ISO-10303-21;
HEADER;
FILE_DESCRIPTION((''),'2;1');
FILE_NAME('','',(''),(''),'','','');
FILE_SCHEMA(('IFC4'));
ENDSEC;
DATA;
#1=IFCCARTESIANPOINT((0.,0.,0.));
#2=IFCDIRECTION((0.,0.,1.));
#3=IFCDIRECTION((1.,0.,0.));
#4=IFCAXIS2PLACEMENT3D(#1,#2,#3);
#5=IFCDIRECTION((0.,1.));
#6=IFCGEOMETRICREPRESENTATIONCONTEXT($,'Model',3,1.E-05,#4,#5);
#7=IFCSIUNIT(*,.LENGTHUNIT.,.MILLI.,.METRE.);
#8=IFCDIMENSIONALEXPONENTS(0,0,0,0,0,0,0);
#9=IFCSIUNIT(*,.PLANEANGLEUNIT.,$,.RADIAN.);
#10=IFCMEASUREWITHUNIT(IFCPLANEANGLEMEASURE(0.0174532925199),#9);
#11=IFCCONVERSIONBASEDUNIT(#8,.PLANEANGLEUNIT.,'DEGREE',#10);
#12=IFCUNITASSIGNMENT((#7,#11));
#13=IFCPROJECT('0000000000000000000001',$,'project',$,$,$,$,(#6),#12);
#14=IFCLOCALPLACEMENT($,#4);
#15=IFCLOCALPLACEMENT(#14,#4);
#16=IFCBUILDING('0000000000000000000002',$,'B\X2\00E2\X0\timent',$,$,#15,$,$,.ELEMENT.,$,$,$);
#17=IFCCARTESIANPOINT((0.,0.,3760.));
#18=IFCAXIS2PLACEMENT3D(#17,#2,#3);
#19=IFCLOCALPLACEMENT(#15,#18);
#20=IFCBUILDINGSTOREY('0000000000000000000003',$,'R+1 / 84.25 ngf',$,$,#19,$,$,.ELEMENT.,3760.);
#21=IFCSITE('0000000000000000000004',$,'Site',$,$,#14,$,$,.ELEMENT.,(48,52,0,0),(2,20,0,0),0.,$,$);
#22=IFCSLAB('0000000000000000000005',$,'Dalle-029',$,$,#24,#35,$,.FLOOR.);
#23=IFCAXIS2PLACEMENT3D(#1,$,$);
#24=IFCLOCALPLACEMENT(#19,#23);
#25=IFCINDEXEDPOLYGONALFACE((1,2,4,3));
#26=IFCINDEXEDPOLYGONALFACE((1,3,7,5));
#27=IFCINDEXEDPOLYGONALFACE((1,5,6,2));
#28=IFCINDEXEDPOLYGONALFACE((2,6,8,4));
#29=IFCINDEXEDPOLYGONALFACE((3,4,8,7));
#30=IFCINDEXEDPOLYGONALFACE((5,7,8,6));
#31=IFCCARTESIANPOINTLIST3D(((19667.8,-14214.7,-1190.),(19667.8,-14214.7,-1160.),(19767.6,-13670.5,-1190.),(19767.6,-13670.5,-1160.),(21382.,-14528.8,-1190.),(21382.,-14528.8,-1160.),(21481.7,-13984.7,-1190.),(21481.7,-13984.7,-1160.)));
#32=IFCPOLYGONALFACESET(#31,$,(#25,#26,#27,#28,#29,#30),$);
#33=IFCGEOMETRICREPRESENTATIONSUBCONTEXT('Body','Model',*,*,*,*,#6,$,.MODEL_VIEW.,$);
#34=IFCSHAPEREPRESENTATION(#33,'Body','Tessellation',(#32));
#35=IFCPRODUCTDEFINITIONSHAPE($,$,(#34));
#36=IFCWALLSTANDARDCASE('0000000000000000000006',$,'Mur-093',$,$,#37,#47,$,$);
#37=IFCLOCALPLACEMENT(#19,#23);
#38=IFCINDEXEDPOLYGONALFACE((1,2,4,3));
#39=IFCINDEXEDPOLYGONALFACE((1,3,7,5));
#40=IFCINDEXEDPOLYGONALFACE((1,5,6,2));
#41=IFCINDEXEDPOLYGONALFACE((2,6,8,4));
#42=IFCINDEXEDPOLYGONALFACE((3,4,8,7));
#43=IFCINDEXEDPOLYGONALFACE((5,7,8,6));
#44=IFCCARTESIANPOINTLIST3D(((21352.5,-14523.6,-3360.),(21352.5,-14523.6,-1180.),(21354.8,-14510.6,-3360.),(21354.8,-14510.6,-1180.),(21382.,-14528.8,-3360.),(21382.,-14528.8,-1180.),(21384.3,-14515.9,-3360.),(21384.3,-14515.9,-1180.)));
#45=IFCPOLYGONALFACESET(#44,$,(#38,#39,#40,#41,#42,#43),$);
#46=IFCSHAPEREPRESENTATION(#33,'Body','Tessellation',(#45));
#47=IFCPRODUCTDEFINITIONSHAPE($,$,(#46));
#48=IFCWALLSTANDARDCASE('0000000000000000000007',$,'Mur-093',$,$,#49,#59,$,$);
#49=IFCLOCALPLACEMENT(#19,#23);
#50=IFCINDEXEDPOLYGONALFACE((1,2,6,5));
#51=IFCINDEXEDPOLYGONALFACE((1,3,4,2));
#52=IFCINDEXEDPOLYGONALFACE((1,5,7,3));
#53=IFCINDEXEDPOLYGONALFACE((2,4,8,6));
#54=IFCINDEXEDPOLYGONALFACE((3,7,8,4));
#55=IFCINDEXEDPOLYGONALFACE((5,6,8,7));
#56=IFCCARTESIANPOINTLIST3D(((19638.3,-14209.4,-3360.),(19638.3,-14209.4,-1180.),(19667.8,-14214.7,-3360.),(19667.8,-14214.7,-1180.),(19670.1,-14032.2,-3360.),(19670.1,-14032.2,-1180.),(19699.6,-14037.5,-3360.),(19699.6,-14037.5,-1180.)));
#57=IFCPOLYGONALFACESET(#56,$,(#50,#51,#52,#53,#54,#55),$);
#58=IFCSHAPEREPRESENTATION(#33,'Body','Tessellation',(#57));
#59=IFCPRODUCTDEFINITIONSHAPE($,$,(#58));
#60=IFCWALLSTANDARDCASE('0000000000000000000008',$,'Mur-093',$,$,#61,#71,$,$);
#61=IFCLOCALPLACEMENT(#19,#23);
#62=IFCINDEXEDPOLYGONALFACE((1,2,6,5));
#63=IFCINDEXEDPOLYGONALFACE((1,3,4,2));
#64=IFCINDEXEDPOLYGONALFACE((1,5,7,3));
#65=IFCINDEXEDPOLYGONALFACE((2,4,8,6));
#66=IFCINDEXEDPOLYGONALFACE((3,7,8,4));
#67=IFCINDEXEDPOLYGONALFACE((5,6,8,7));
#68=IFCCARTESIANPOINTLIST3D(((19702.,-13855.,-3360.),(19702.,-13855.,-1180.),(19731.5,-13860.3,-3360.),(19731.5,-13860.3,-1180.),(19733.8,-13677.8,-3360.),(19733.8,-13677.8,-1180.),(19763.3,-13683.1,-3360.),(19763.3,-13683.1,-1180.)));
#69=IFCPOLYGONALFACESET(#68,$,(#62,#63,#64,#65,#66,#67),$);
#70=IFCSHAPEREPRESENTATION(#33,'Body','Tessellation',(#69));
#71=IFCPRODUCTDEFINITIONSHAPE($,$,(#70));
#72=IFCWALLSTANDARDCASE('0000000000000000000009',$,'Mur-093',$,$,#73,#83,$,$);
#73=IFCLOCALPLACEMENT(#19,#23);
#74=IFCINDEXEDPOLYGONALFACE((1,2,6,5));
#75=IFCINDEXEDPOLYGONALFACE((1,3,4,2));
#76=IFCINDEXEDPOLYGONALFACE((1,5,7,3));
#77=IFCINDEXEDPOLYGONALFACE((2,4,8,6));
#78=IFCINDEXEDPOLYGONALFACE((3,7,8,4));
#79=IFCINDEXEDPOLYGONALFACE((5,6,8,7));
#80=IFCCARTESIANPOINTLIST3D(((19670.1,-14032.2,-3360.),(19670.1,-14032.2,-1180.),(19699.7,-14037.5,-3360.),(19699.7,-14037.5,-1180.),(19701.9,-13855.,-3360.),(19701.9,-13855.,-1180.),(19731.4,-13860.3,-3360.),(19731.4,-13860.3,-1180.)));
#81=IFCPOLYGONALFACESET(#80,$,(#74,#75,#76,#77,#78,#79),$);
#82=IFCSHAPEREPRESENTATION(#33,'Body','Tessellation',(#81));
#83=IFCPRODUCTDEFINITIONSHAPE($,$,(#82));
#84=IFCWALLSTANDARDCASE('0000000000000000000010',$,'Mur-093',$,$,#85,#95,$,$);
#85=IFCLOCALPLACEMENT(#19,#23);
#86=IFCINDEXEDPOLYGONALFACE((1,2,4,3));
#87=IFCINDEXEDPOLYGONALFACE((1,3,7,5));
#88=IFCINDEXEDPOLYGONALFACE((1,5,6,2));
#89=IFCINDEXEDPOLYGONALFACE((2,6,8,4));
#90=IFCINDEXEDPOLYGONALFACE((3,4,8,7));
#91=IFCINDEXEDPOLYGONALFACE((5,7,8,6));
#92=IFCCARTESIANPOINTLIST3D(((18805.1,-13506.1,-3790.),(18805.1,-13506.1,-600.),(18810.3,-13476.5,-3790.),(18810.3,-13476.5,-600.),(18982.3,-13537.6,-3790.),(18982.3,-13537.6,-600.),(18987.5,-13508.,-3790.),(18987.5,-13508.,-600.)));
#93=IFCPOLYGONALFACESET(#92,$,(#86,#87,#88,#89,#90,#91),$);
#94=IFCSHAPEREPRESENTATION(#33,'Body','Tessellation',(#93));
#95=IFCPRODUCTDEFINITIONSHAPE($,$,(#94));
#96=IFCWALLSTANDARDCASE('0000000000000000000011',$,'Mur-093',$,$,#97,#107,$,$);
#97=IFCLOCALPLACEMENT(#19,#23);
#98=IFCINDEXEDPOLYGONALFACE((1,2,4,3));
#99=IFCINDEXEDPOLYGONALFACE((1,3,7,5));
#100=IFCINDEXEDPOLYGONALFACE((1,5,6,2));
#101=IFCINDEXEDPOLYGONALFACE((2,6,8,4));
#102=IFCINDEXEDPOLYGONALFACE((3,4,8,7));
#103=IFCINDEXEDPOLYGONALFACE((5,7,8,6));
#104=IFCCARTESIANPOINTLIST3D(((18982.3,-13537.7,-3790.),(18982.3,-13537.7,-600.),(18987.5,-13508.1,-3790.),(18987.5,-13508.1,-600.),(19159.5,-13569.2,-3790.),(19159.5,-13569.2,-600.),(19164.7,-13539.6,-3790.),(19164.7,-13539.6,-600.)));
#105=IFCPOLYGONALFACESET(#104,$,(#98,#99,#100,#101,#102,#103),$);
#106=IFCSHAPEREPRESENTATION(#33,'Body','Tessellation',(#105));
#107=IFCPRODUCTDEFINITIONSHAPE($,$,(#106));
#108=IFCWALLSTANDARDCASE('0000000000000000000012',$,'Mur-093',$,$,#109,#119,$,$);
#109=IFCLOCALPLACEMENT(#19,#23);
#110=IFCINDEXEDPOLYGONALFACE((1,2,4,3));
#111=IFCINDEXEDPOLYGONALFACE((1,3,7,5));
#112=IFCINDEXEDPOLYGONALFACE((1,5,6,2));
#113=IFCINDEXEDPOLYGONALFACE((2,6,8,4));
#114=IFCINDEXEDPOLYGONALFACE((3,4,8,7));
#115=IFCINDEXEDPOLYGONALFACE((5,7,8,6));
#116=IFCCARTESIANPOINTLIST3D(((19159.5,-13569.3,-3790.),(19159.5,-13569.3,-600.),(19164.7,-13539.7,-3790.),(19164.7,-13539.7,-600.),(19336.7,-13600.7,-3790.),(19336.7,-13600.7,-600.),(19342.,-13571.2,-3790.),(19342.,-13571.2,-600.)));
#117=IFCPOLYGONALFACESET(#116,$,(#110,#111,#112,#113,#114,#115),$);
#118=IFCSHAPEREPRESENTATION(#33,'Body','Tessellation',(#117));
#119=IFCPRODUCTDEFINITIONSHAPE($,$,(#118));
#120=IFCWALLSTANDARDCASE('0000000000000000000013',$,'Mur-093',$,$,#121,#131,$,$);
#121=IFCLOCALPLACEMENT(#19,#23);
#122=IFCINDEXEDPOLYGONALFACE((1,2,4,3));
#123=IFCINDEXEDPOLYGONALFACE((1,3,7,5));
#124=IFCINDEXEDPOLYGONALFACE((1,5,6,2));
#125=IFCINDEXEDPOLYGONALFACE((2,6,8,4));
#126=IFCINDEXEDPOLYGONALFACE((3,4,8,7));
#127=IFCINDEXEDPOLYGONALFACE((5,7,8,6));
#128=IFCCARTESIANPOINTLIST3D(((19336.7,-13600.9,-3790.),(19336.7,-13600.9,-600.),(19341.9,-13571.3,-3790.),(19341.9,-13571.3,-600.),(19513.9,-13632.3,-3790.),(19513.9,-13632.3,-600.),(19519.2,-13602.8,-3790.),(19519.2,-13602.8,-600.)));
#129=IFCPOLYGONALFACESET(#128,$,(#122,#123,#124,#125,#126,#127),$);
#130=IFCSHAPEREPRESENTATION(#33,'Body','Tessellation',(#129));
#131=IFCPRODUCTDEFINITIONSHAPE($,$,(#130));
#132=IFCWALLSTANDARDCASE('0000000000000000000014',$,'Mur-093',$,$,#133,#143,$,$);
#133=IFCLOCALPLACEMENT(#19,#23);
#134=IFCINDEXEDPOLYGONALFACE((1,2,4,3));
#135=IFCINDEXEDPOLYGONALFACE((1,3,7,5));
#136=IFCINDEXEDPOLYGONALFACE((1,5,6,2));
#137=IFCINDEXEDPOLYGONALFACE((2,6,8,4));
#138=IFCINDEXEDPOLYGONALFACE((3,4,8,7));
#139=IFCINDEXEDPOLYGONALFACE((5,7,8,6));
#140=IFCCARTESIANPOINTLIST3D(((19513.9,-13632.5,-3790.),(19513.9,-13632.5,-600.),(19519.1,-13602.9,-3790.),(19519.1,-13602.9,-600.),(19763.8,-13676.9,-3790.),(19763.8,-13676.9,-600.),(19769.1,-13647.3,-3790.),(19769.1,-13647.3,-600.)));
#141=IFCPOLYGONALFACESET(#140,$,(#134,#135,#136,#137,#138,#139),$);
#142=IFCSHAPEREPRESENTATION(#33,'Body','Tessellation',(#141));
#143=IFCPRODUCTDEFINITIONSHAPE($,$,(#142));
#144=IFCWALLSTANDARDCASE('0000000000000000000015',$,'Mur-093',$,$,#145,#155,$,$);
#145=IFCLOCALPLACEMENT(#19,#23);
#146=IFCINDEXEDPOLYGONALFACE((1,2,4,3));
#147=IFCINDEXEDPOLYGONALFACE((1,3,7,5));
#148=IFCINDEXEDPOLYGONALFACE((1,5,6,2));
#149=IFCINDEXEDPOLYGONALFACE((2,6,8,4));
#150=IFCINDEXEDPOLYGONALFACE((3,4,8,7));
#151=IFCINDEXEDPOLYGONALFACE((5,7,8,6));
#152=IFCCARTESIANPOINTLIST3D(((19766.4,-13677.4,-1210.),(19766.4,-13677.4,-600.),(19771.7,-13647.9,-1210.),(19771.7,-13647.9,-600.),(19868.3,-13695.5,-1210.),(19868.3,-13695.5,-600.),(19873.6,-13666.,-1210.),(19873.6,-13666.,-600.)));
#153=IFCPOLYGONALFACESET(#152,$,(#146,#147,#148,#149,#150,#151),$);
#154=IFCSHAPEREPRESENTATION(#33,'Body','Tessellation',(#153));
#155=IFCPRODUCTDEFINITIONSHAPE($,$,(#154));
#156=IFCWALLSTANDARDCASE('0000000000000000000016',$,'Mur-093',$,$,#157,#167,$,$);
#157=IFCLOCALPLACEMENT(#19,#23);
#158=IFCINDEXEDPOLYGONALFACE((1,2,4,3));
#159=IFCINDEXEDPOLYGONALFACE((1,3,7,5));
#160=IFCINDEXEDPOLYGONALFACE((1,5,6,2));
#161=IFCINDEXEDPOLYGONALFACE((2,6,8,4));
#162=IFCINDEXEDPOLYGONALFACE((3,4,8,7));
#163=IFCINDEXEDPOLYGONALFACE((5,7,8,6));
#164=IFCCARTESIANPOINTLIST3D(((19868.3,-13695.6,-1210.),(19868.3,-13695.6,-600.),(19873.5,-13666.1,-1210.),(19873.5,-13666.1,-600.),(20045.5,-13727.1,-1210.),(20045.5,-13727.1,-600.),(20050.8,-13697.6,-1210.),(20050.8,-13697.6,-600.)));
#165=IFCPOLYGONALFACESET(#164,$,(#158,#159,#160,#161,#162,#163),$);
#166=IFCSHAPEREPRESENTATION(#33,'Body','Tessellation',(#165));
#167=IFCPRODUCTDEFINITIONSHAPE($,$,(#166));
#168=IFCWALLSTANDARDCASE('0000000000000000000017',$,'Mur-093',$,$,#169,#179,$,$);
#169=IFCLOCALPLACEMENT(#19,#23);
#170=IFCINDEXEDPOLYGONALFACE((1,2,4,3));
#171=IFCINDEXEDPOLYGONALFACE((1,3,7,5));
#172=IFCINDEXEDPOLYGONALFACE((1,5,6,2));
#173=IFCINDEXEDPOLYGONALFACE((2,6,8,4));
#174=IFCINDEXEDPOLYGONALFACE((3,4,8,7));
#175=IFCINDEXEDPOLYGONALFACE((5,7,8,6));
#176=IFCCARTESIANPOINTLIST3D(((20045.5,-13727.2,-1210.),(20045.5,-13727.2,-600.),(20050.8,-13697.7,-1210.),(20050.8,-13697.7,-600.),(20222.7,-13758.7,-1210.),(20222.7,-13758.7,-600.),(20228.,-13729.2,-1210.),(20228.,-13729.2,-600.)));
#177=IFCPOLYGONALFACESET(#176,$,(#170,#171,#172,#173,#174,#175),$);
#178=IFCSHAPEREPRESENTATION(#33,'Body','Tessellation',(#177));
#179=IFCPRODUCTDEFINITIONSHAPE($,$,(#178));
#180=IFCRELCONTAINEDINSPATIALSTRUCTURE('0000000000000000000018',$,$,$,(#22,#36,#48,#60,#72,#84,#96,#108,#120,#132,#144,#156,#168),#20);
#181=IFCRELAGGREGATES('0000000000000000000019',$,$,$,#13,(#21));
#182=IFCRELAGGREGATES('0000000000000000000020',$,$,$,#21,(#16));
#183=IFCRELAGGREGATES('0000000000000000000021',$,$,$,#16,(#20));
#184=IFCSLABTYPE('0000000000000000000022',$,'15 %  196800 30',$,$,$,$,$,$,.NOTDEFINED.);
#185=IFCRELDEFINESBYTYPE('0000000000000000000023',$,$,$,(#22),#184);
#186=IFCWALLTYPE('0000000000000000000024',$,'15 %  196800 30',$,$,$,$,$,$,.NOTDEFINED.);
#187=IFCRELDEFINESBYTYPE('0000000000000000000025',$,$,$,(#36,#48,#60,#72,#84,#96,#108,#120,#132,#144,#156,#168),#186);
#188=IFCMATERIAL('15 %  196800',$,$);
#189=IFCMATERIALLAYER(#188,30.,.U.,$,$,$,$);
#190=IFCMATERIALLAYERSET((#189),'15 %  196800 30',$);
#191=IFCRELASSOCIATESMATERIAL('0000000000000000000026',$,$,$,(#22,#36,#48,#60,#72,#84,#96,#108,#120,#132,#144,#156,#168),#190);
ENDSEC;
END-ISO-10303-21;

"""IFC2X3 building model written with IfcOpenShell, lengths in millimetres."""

from ifc_helpers import new_model, entity, si_unit, converted_unit, direction, frame, origin_with_axes, place, context, subcontext, project, spatial, polyline, outline, extrude, material, layer, layer_set, layer_usage, type_object, element, save


model = new_model("IFC2X3")

# Units and contexts
model_context = context("Model", 3, precision=1e-05, world=origin_with_axes(), true_north=direction((0.0, 1.0)))
body_context = subcontext(model_context, "Body", "Model", "MODEL_VIEW")
ifc_project = project(units=[si_unit("LENGTHUNIT", "METRE", prefix="MILLI"), converted_unit("PLANEANGLEUNIT", "DEGREE", entity("IfcPlaneAngleMeasure", 0.0174532925199), si_unit("PLANEANGLEUNIT", "RADIAN"), dimensions=[0, 0, 0, 0, 0, 0, 0])], contexts=[model_context])

# Site, building, storey
site_placement = place(None, origin_with_axes())
site = spatial("IfcSite", under=ifc_project, at=site_placement, Name="Site", CompositionType="ELEMENT", RefLatitude=(48, 52, 0, 0), RefLongitude=(2, 20, 0, 0), RefElevation=0.0)
building_placement = place(site_placement, origin_with_axes())
building = spatial("IfcBuilding", under=site, at=building_placement, Name="Bâtiment", CompositionType="ELEMENT")
storey_placement = place(building_placement, frame((0.0, 0.0, 3760.0), z_axis=(0.0, 0.0, 1.0), x_axis=(1.0, 0.0, 0.0)))
storey = spatial("IfcBuildingStorey", under=building, at=storey_placement, Name="R+1 / 84.25 ngf", CompositionType="ELEMENT", Elevation=3760.0)

# Slab
ifc_material = material(Name="15 %  196800")
ifc_layer = layer(ifc_material, 30.0, ventilated="UNKNOWN")
ifc_layer_set = layer_set([ifc_layer], Name="15 %  196800 30")
ifc_layer_usage_1 = layer_usage(ifc_layer_set, "AXIS3", "NEGATIVE", 30.0)
slab_type = type_object("IfcSlabType", Name="15 %  196800 30", PredefinedType="NOTDEFINED")
slab_placement = place(storey_placement, frame((21382.0, -14528.8, -1160.0), z_axis=(0.0, 0.0, 1.0), x_axis=(1.0, 0.0, 0.0)))
element("IfcSlab", 1, at=slab_placement, inside=storey, type_object=slab_type, material=ifc_layer_usage_1, Name="Dalle-029", PredefinedType="FLOOR", context=body_context, shape_type="SweptSolid", body=[
    extrude(outline(polyline([(0.0, 0.0), (99.7, 544.1), (-1614.5, 858.3), (-1714.2, 314.2), (0.0, 0.0)])), frame((0.0, 0.0, -30.0), z_axis=(0.0, 0.0, 1.0), x_axis=(1.0, 0.0, 0.0)), (0.0, 0.0, 1.0), 30.0),
])

# Walls
ifc_layer_usage_2 = layer_usage(ifc_layer_set, "AXIS2", "NEGATIVE", 30.0)
wall_type = type_object("IfcWallType", Name="15 %  196800 30", PredefinedType="NOTDEFINED")
wall_1_placement = place(storey_placement, frame((21354.8, -14510.6, -3360.0), z_axis=(0.0, 0.0, 1.0), x_axis=(-0.176462, -0.984308, 0.0)))
element("IfcWallStandardCase", 2, at=wall_1_placement, inside=storey, type_object=wall_type, material=ifc_layer_usage_2, Name="Mur-093", context=body_context, shape_type="SweptSolid", body=[
    extrude(outline(polyline([(0.0, 0.0), (13.1, 0.0), (13.1, 30.0), (0.0, 30.0), (0.0, 0.0)])), origin_with_axes(), (0.0, 0.0, 1.0), 2180.0),
])
ifc_layer_usage_3 = layer_usage(ifc_layer_set, "AXIS2", "POSITIVE", -30.0)
wall_2_placement = place(storey_placement, frame((19699.6, -14037.5, -3360.0), z_axis=(0.0, 0.0, 1.0), x_axis=(-0.176462, -0.984308, 0.0)))
element("IfcWallStandardCase", 3, at=wall_2_placement, inside=storey, type_object=wall_type, material=ifc_layer_usage_3, Name="Mur-093", context=body_context, shape_type="SweptSolid", body=[
    extrude(outline(polyline([(0.0, -30.0), (180.0, -30.0), (180.0, 0.0), (0.0, 0.0), (0.0, -30.0)])), origin_with_axes(), (0.0, 0.0, 1.0), 2180.0),
])
ifc_layer_usage_4 = layer_usage(ifc_layer_set, "AXIS2", "POSITIVE", -30.0)
wall_3_placement = place(storey_placement, frame((19763.3, -13683.1, -3360.0), z_axis=(0.0, 0.0, 1.0), x_axis=(-0.176462, -0.984308, 0.0)))
element("IfcWallStandardCase", 4, at=wall_3_placement, inside=storey, type_object=wall_type, material=ifc_layer_usage_4, Name="Mur-093", context=body_context, shape_type="SweptSolid", body=[
    extrude(outline(polyline([(0.0, -30.0), (180.0, -30.0), (180.0, 0.0), (0.0, 0.0), (0.0, -30.0)])), origin_with_axes(), (0.0, 0.0, 1.0), 2180.0),
])
ifc_layer_usage_5 = layer_usage(ifc_layer_set, "AXIS2", "POSITIVE", -30.0)
wall_4_placement = place(storey_placement, frame((19731.4, -13860.3, -3360.0), z_axis=(0.0, 0.0, 1.0), x_axis=(-0.176462, -0.984308, 0.0)))
element("IfcWallStandardCase", 5, at=wall_4_placement, inside=storey, type_object=wall_type, material=ifc_layer_usage_5, Name="Mur-093", context=body_context, shape_type="SweptSolid", body=[
    extrude(outline(polyline([(0.0, -30.0), (180.0, -30.0), (180.0, 0.0), (0.0, 0.0), (0.0, -30.0)])), origin_with_axes(), (0.0, 0.0, 1.0), 2180.0),
])
ifc_layer_usage_6 = layer_usage(ifc_layer_set, "AXIS2", "NEGATIVE", 30.0)
wall_5_placement = place(storey_placement, frame((18987.5, -13508.0, -3790.0), z_axis=(0.0, 0.0, 1.0), x_axis=(-0.984592, 0.174869, 0.0)))
element("IfcWallStandardCase", 6, at=wall_5_placement, inside=storey, type_object=wall_type, material=ifc_layer_usage_6, Name="Mur-093", context=body_context, shape_type="SweptSolid", body=[
    extrude(outline(polyline([(0.0, 0.0), (180.0, 0.0), (180.0, 30.0), (0.0, 30.0), (0.0, 0.0)])), origin_with_axes(), (0.0, 0.0, 1.0), 3190.0),
])
ifc_layer_usage_7 = layer_usage(ifc_layer_set, "AXIS2", "NEGATIVE", 30.0)
wall_6_placement = place(storey_placement, frame((19164.7, -13539.6, -3790.0), z_axis=(0.0, 0.0, 1.0), x_axis=(-0.984592, 0.174869, 0.0)))
element("IfcWallStandardCase", 7, at=wall_6_placement, inside=storey, type_object=wall_type, material=ifc_layer_usage_7, Name="Mur-093", context=body_context, shape_type="SweptSolid", body=[
    extrude(outline(polyline([(0.0, 0.0), (180.0, 0.0), (180.0, 30.0), (0.0, 30.0), (0.0, 0.0)])), origin_with_axes(), (0.0, 0.0, 1.0), 3190.0),
])
ifc_layer_usage_8 = layer_usage(ifc_layer_set, "AXIS2", "NEGATIVE", 30.0)
wall_7_placement = place(storey_placement, frame((19342.0, -13571.2, -3790.0), z_axis=(0.0, 0.0, 1.0), x_axis=(-0.984592, 0.174869, 0.0)))
element("IfcWallStandardCase", 8, at=wall_7_placement, inside=storey, type_object=wall_type, material=ifc_layer_usage_8, Name="Mur-093", context=body_context, shape_type="SweptSolid", body=[
    extrude(outline(polyline([(0.0, 0.0), (180.0, 0.0), (180.0, 30.0), (0.0, 30.0), (0.0, 0.0)])), origin_with_axes(), (0.0, 0.0, 1.0), 3190.0),
])
ifc_layer_usage_9 = layer_usage(ifc_layer_set, "AXIS2", "NEGATIVE", 30.0)
wall_8_placement = place(storey_placement, frame((19519.2, -13602.8, -3790.0), z_axis=(0.0, 0.0, 1.0), x_axis=(-0.984592, 0.174869, 0.0)))
element("IfcWallStandardCase", 9, at=wall_8_placement, inside=storey, type_object=wall_type, material=ifc_layer_usage_9, Name="Mur-093", context=body_context, shape_type="SweptSolid", body=[
    extrude(outline(polyline([(0.0, 0.0), (180.0, 0.0), (180.0, 30.0), (0.0, 30.0), (0.0, 0.0)])), origin_with_axes(), (0.0, 0.0, 1.0), 3190.0),
])
ifc_layer_usage_10 = layer_usage(ifc_layer_set, "AXIS2", "NEGATIVE", 30.0)
wall_9_placement = place(storey_placement, frame((19769.1, -13647.3, -3790.0), z_axis=(0.0, 0.0, 1.0), x_axis=(-0.984592, 0.174869, 0.0)))
element("IfcWallStandardCase", 10, at=wall_9_placement, inside=storey, type_object=wall_type, material=ifc_layer_usage_10, Name="Mur-093", context=body_context, shape_type="SweptSolid", body=[
    extrude(outline(polyline([(0.0, 0.0), (253.9, 0.0), (253.9, 30.0), (0.0, 30.0), (0.0, 0.0)])), origin_with_axes(), (0.0, 0.0, 1.0), 3190.0),
])
ifc_layer_usage_11 = layer_usage(ifc_layer_set, "AXIS2", "NEGATIVE", 30.0)
wall_10_placement = place(storey_placement, frame((19873.6, -13666.0, -1210.0), z_axis=(0.0, 0.0, 1.0), x_axis=(-0.984592, 0.174869, 0.0)))
element("IfcWallStandardCase", 11, at=wall_10_placement, inside=storey, type_object=wall_type, material=ifc_layer_usage_11, Name="Mur-093", context=body_context, shape_type="SweptSolid", body=[
    extrude(outline(polyline([(0.0, 0.0), (103.5, 0.0), (103.5, 30.0), (0.0, 30.0), (0.0, 0.0)])), origin_with_axes(), (0.0, 0.0, 1.0), 610.0),
])
ifc_layer_usage_12 = layer_usage(ifc_layer_set, "AXIS2", "NEGATIVE", 30.0)
wall_11_placement = place(storey_placement, frame((20050.8, -13697.6, -1210.0), z_axis=(0.0, 0.0, 1.0), x_axis=(-0.984592, 0.174869, 0.0)))
element("IfcWallStandardCase", 12, at=wall_11_placement, inside=storey, type_object=wall_type, material=ifc_layer_usage_12, Name="Mur-093", context=body_context, shape_type="SweptSolid", body=[
    extrude(outline(polyline([(0.0, 0.0), (180.0, 0.0), (180.0, 30.0), (0.0, 30.0), (0.0, 0.0)])), origin_with_axes(), (0.0, 0.0, 1.0), 610.0),
])
ifc_layer_usage_13 = layer_usage(ifc_layer_set, "AXIS2", "NEGATIVE", 30.0)
wall_12_placement = place(storey_placement, frame((20228.0, -13729.2, -1210.0), z_axis=(0.0, 0.0, 1.0), x_axis=(-0.984592, 0.174869, 0.0)))
element("IfcWallStandardCase", 13, at=wall_12_placement, inside=storey, type_object=wall_type, material=ifc_layer_usage_13, Name="Mur-093", context=body_context, shape_type="SweptSolid", body=[
    extrude(outline(polyline([(0.0, 0.0), (180.0, 0.0), (180.0, 30.0), (0.0, 30.0), (0.0, 0.0)])), origin_with_axes(), (0.0, 0.0, 1.0), 610.0),
])

save(model, "model.ifc")
